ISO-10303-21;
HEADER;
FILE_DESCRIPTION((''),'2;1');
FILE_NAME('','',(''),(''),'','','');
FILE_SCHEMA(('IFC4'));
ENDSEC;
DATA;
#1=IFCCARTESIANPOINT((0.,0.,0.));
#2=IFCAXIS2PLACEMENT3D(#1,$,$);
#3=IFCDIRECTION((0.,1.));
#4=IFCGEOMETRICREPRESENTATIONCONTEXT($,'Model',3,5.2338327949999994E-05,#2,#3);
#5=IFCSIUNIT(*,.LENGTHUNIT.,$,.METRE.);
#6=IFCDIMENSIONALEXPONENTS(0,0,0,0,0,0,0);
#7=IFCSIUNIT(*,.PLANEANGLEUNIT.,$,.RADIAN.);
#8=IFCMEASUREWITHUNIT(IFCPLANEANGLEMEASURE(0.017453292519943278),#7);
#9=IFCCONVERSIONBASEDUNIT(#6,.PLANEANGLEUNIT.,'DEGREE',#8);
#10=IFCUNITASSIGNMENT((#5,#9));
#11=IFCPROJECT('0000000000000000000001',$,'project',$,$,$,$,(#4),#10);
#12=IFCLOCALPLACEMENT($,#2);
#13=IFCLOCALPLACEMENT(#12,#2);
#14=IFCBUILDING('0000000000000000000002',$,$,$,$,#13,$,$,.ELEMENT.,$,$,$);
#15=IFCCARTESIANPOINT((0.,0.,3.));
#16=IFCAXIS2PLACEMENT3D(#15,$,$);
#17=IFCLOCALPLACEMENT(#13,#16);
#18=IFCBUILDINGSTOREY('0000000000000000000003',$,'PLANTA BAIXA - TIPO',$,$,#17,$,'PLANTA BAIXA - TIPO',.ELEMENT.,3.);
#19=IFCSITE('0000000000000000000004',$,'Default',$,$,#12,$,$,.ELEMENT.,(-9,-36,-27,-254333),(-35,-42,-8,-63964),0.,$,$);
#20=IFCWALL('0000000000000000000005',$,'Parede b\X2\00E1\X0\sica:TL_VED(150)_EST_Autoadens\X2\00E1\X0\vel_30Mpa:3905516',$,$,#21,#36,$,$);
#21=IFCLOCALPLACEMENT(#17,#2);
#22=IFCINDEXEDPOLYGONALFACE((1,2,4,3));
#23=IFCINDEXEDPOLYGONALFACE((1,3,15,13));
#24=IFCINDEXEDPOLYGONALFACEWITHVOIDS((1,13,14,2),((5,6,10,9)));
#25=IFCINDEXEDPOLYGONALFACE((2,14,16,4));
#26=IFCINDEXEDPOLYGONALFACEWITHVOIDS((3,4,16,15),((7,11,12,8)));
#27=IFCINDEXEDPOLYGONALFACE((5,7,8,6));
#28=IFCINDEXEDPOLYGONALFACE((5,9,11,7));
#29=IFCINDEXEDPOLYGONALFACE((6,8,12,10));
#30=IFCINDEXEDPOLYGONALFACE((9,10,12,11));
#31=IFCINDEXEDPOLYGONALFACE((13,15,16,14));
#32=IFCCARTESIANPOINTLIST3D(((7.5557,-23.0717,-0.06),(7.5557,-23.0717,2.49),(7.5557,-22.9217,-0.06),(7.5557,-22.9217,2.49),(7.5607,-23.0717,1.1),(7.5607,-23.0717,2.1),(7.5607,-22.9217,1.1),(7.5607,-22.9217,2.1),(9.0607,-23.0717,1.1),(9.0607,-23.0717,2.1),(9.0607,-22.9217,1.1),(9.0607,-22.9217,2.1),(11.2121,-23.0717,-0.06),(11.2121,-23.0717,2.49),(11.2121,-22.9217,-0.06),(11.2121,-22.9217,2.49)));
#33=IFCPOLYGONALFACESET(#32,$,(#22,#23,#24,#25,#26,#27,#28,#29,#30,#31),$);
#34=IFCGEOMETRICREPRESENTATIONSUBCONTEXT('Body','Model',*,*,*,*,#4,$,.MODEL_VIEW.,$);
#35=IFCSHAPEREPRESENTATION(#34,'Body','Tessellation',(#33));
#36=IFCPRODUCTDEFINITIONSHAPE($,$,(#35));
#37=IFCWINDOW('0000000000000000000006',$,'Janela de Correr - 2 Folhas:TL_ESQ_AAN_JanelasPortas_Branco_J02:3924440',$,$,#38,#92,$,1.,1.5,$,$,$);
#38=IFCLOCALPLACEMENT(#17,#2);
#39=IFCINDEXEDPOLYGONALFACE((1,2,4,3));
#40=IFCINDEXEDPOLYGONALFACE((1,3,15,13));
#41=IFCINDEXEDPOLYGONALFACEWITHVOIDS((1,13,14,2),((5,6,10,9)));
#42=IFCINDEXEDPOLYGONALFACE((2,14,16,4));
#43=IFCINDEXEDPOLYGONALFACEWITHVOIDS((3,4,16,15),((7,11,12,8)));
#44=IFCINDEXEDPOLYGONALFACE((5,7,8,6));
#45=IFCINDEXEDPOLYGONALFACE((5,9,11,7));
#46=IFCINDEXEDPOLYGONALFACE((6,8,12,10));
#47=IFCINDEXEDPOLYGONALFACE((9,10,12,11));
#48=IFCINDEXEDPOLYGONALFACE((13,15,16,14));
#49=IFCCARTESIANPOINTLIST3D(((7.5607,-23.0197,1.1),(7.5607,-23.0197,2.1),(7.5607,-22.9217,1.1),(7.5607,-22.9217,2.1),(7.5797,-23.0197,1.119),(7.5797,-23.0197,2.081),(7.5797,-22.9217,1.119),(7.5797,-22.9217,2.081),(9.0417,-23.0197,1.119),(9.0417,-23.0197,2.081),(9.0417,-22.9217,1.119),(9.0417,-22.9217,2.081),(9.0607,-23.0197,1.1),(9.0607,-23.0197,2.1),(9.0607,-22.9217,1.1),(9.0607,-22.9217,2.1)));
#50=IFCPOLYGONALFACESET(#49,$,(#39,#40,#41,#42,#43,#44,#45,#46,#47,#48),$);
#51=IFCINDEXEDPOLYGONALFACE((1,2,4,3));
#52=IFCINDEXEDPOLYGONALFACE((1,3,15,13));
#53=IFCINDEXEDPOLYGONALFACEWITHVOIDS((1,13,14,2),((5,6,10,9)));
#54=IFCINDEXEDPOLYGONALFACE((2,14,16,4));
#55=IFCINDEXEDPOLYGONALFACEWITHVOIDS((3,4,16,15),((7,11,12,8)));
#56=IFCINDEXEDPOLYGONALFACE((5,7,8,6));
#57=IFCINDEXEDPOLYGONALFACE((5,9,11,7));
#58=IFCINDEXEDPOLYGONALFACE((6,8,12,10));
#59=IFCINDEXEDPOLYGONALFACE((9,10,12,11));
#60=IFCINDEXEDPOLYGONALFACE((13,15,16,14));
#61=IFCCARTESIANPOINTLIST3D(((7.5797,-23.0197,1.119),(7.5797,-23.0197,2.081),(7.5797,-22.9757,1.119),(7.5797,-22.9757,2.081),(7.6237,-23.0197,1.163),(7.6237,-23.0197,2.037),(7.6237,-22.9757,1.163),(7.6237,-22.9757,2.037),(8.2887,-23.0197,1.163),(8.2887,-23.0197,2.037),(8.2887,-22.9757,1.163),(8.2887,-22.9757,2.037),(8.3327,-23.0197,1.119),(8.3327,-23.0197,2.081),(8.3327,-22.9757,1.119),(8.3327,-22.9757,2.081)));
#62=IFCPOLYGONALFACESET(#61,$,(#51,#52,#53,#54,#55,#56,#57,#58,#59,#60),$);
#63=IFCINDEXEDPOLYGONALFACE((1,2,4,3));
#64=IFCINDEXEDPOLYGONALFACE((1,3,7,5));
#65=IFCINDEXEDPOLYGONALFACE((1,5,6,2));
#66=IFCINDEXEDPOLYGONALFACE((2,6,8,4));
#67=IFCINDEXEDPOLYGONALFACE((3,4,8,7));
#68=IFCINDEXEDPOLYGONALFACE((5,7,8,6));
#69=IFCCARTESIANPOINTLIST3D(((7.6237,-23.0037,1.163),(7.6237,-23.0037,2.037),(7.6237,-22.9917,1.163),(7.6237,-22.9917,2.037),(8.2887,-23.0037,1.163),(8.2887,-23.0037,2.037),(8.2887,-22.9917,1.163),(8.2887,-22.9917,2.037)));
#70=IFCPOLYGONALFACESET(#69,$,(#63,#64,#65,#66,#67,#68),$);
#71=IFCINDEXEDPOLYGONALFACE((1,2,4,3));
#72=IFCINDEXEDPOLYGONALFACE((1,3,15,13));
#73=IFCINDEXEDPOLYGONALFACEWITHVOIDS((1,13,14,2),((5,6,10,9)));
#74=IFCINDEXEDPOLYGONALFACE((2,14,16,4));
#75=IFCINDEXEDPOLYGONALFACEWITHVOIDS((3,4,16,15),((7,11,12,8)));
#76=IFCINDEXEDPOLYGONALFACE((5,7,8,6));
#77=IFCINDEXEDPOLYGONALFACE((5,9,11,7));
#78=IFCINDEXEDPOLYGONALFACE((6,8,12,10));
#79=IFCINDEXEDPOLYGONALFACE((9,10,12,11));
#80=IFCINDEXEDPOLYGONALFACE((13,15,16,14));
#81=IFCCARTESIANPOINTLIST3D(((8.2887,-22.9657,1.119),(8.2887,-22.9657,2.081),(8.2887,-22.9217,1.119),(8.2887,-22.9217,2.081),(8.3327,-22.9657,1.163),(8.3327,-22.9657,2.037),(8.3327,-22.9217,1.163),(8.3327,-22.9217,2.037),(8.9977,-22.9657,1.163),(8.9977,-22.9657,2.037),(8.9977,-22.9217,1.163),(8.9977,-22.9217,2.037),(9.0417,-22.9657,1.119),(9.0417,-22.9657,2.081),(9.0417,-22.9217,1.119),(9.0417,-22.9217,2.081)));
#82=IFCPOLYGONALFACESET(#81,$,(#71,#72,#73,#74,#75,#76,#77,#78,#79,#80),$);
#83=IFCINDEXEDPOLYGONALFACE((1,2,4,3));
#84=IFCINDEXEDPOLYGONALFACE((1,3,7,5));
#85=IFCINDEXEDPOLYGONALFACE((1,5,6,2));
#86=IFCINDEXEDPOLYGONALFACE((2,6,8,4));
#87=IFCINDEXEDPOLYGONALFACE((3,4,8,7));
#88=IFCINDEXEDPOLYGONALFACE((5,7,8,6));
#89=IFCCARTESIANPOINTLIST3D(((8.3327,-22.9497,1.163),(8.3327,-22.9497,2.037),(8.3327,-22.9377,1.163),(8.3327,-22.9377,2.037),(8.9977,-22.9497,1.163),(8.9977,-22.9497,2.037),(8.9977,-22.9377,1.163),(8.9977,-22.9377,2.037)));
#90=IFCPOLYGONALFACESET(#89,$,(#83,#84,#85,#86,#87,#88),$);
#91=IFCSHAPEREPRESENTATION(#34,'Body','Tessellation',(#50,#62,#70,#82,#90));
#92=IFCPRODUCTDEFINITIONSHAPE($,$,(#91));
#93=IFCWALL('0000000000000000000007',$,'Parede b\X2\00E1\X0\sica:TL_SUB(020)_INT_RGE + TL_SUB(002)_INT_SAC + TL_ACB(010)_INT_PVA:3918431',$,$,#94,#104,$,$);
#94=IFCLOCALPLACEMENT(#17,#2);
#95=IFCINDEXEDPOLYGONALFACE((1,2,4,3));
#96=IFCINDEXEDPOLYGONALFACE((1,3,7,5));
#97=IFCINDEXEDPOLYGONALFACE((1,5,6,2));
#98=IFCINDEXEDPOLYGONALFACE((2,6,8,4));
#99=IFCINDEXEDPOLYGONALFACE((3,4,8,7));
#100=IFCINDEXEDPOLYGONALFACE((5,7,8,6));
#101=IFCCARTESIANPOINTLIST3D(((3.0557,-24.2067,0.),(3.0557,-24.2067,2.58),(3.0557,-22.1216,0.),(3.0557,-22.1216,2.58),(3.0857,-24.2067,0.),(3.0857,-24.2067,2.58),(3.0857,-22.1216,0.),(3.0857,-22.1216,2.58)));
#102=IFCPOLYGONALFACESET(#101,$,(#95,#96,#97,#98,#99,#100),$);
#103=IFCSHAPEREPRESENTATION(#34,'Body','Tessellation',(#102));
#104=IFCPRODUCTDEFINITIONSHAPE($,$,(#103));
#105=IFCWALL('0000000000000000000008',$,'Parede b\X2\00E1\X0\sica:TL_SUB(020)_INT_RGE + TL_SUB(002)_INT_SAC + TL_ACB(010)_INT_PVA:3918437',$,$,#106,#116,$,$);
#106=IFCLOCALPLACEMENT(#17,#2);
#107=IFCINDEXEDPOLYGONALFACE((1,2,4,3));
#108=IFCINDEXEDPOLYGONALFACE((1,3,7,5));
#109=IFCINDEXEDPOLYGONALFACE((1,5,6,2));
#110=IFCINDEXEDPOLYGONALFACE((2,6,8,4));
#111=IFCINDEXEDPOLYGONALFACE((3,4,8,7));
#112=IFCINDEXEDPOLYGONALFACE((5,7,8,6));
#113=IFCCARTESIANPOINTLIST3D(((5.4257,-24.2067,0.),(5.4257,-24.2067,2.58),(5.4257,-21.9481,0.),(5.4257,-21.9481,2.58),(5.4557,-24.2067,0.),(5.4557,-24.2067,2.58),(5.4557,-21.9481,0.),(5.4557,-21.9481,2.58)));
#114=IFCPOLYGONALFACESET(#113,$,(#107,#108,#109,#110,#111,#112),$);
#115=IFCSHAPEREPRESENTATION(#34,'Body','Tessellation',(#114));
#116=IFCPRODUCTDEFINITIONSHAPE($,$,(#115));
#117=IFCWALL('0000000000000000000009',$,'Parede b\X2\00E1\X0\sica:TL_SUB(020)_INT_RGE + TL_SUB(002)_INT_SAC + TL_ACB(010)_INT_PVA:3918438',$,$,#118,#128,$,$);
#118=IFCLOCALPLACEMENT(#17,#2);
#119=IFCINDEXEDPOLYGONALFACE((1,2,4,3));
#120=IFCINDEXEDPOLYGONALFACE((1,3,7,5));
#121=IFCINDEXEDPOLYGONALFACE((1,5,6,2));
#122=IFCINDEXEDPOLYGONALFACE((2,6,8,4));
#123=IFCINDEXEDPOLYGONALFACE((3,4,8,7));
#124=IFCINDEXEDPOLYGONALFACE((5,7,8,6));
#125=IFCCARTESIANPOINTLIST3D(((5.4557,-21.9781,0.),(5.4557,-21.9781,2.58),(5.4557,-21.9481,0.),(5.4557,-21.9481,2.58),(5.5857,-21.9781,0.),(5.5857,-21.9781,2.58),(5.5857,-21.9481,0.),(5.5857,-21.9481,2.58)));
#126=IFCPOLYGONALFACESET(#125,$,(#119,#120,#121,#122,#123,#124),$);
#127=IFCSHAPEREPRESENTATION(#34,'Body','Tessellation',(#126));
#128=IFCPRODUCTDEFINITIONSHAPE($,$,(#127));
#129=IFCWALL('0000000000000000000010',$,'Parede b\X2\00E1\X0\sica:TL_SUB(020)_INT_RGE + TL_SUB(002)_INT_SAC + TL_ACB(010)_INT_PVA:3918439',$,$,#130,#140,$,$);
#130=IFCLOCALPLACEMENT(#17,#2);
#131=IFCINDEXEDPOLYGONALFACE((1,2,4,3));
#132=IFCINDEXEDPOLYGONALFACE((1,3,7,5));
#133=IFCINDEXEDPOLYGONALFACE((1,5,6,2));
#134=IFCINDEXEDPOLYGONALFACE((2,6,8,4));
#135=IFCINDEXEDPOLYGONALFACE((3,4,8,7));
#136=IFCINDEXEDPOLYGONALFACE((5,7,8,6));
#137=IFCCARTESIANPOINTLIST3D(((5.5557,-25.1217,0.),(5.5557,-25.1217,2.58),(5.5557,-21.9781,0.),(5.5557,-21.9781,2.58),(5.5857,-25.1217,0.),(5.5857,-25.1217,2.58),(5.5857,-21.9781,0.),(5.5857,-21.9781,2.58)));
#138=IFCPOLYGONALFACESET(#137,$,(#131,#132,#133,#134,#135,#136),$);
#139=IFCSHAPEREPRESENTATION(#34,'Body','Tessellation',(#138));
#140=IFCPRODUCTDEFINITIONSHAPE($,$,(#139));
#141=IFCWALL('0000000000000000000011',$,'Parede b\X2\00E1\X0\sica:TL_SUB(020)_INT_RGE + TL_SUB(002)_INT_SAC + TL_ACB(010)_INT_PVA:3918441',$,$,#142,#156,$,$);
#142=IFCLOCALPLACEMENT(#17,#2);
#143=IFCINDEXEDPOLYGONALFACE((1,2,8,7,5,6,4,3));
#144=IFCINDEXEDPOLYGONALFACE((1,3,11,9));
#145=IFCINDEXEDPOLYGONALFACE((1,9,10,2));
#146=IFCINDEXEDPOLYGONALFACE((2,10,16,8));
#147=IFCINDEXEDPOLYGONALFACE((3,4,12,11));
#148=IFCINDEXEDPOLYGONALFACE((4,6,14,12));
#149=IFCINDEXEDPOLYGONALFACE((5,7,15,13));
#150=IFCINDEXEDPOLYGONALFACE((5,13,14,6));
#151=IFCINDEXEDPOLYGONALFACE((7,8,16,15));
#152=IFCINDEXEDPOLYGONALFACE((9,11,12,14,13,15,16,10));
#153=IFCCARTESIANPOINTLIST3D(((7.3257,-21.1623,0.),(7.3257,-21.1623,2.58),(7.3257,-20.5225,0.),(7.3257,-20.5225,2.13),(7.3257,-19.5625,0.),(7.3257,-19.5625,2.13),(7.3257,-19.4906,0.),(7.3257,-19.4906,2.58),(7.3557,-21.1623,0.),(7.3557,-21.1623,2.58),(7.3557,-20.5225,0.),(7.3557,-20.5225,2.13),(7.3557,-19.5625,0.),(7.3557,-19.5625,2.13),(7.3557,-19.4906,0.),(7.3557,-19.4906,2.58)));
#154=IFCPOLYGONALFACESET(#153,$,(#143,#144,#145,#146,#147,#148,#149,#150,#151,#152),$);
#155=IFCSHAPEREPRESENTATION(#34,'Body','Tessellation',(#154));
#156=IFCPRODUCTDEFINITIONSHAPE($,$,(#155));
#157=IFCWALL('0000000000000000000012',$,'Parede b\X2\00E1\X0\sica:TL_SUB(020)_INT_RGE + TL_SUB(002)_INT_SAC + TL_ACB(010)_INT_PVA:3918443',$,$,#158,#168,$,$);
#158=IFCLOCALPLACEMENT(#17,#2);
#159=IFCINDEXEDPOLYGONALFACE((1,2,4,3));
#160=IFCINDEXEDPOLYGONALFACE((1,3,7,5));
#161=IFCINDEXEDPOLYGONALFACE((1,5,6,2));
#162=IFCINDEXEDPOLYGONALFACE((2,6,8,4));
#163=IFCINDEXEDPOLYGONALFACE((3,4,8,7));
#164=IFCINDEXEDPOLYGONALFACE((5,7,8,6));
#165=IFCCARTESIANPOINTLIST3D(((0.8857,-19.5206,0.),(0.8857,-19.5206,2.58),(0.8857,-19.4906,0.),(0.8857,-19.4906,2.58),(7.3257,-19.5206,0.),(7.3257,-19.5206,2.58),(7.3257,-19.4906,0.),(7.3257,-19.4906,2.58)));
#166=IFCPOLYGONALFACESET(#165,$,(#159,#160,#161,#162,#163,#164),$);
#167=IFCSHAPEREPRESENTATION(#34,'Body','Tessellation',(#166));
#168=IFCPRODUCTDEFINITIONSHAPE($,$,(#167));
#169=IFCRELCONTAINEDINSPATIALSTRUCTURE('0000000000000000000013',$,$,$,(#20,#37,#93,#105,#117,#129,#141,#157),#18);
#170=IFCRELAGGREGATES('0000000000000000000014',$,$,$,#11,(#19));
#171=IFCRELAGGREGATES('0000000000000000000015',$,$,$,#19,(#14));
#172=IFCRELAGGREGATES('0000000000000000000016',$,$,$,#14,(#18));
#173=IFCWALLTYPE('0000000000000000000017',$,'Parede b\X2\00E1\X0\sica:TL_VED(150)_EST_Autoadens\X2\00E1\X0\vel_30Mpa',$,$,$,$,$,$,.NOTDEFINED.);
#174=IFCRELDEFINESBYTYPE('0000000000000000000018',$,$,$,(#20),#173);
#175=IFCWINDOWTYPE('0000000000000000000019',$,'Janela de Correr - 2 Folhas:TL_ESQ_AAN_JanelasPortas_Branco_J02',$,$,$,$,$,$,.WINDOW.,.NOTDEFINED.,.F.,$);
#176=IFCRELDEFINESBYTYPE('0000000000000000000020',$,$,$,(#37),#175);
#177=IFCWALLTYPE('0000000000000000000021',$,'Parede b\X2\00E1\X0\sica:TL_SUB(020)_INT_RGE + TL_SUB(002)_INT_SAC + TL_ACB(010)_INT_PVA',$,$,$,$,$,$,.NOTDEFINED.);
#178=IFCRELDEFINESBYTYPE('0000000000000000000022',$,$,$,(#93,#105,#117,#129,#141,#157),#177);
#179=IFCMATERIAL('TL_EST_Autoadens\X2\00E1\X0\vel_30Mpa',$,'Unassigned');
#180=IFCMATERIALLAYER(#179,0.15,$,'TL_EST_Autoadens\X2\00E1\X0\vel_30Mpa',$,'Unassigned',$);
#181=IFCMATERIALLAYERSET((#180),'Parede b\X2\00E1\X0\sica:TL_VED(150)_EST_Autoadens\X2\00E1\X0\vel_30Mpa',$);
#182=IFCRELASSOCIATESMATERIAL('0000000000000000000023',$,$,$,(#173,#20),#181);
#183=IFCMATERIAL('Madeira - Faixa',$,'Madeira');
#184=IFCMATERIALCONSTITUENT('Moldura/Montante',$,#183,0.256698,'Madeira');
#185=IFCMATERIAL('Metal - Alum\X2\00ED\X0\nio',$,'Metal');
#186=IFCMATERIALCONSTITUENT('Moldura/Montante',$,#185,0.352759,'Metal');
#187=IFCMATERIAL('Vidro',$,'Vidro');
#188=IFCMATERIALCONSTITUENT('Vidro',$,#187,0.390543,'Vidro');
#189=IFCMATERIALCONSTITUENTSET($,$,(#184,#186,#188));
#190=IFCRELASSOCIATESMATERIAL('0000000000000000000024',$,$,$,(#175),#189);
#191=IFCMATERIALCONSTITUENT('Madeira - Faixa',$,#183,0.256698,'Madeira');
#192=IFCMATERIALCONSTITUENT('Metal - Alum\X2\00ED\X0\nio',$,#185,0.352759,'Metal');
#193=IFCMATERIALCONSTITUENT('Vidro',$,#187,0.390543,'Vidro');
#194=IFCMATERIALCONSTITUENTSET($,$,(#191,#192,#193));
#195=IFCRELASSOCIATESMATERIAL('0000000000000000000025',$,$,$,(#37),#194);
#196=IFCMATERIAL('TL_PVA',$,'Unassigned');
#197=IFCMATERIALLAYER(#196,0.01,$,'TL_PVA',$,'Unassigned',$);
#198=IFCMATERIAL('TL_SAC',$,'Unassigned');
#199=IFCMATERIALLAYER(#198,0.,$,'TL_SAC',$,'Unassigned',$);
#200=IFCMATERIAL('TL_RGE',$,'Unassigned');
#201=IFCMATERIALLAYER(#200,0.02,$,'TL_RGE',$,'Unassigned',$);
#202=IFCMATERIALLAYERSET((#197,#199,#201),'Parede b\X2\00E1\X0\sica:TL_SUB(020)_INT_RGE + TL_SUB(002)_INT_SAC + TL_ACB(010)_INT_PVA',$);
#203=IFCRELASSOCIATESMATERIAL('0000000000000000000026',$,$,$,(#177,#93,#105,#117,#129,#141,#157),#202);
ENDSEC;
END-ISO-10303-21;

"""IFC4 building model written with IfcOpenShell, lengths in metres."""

from ifc_helpers import new_model, entity, si_unit, converted_unit, direction, frame, frame_2d, origin, origin_2d_with_axis, place, context, subcontext, project, spatial, polyline, rectangle, outline, extrude, source, transform, mapped, material, layer, layer_set, layer_usage, constituent, constituent_set, type_object, type_shapes, element, fill, save


model = new_model("IFC4")

# Units and contexts
model_context = context("Model", 3, precision=5.2338327949999994e-05, world=origin(), true_north=direction((0.0, 1.0)))
body_context = subcontext(model_context, "Body", "Model", "MODEL_VIEW")
ifc_project = project(units=[si_unit("LENGTHUNIT", "METRE"), converted_unit("PLANEANGLEUNIT", "DEGREE", entity("IfcPlaneAngleMeasure", 0.017453292519943278), si_unit("PLANEANGLEUNIT", "RADIAN"), dimensions=[0, 0, 0, 0, 0, 0, 0])], contexts=[model_context])

# Site, building, storey
site_placement = place(None, frame((0.0, 0.0, 0.0)))
site = spatial("IfcSite", under=ifc_project, at=site_placement, Name="Default", CompositionType="ELEMENT", RefLatitude=(-9, -36, -27, -254333), RefLongitude=(-35, -42, -8, -63964), RefElevation=0.0)
building_placement = place(site_placement, origin())
building = spatial("IfcBuilding", under=site, at=building_placement, CompositionType="ELEMENT")
storey_placement = place(building_placement, frame((0.0, 0.0, 3.0)))
storey = spatial("IfcBuildingStorey", under=building, at=storey_placement, Name="PLANTA BAIXA - TIPO", LongName="PLANTA BAIXA - TIPO", CompositionType="ELEMENT", Elevation=3.0)

# Shared definitions
ifc_material_1 = material(Name="TL_EST_Autoadensável_30Mpa", Category="Unassigned")

# Wall, opening, window
ifc_material_2 = material(Name="Madeira - Faixa", Category="Madeira")
ifc_material_3 = material(Name="Metal - Alumínio", Category="Metal")
ifc_material_4 = material(Name="Vidro", Category="Vidro")
ifc_layer_1 = layer(ifc_material_1, 0.15, Name="TL_EST_Autoadensável_30Mpa", Category="Unassigned")
ifc_layer_set_1 = layer_set([ifc_layer_1], Name="Parede básica:TL_VED(150)_EST_Autoadensável_30Mpa")
ifc_layer_usage_1 = layer_usage(ifc_layer_set_1, "AXIS2", "POSITIVE", -0.075)
wall_type_1 = type_object("IfcWallType", Name="Parede básica:TL_VED(150)_EST_Autoadensável_30Mpa", PredefinedType="NOTDEFINED", material=ifc_layer_set_1)
wall_1_placement = place(storey_placement, frame((7.5557, -22.9967, -0.06)))
wall_1 = element("IfcWall", 1, at=wall_1_placement, inside=storey, type_object=wall_type_1, material=ifc_layer_usage_1, Name="Parede básica:TL_VED(150)_EST_Autoadensável_30Mpa:3905516", context=body_context, shape_type="SweptSolid", body=[
    extrude(rectangle(XDim=3.6564, YDim=0.15, at=frame_2d((1.8282, 0.0), x_axis=(-1.0, 0.0))), origin(), (0.0, 0.0, 1.0), 2.55),
])
opening_1_placement = place(wall_1_placement, frame((1.505, 0.075, 1.16)))
opening_1 = element("IfcOpeningElement", 2, at=opening_1_placement, cuts=wall_1, PredefinedType="OPENING", context=body_context, shape_type="SweptSolid", body=[
    extrude(rectangle(XDim=1.0, YDim=1.5, at=frame_2d((0.5, 0.75), x_axis=(-1.0, 0.0))), frame((0.0, 0.0, 0.0), z_axis=(0.0, -1.0, 0.0), x_axis=(0.0, 0.0, 1.0)), (0.0, 0.0, 1.0), 0.15),
])
ifc_constituent_1 = constituent(ifc_material_2, Name="Madeira - Faixa", Category="Madeira", fraction=0.256698)
ifc_constituent_2 = constituent(ifc_material_3, Name="Metal - Alumínio", Category="Metal", fraction=0.352759)
ifc_constituent_3 = constituent(ifc_material_4, Name="Vidro", Category="Vidro", fraction=0.390543)
ifc_constituent_set_1 = constituent_set(constituents=[ifc_constituent_1, ifc_constituent_2, ifc_constituent_3])
ifc_constituent_4 = constituent(ifc_material_2, Name="Moldura/Montante", Category="Madeira", fraction=0.256698)
ifc_constituent_5 = constituent(ifc_material_3, Name="Moldura/Montante", Category="Metal", fraction=0.352759)
ifc_constituent_6 = constituent(ifc_material_4, Name="Vidro", Category="Vidro", fraction=0.390543)
ifc_constituent_set_2 = constituent_set(constituents=[ifc_constituent_4, ifc_constituent_5, ifc_constituent_6])
window_type_1 = type_object("IfcWindowType", Name="Janela de Correr - 2 Folhas:TL_ESQ_AAN_JanelasPortas_Branco_J02", ParameterTakesPrecedence=False, PartitioningType="NOTDEFINED", PredefinedType="WINDOW", material=ifc_constituent_set_2)
shared_shape_1 = source(origin(), body_context, "Body", "SweptSolid", [
    extrude(outline(polyline([(-0.75, -0.5), (0.75, -0.5), (0.75, 0.5), (-0.75, 0.5), (-0.75, -0.5)]), holes=[polyline([(-0.731, -0.481), (-0.731, 0.481), (0.731, 0.481), (0.731, -0.481), (-0.731, -0.481)])]), frame((0.75, 0.0, 0.5), z_axis=(0.0, 1.0, 0.0), x_axis=(1.0, 0.0, 0.0)), (0.0, 0.0, 1.0), 0.098),
    extrude(outline(polyline([(-0.3765, -0.481), (0.3765, -0.481), (0.3765, 0.481), (-0.3765, 0.481), (-0.3765, -0.481)]), holes=[polyline([(-0.3325, -0.437), (-0.3325, 0.437), (0.3325, 0.437), (0.3325, -0.437), (-0.3325, -0.437)])]), frame((1.1045, 0.054, 0.5), z_axis=(0.0, 1.0, 0.0), x_axis=(1.0, 0.0, 0.0)), (0.0, 0.0, 1.0), 0.044),
    extrude(rectangle(XDim=0.012, YDim=0.665, at=origin_2d_with_axis()), frame((1.1045, 0.076, 0.063), z_axis=(0.0, 0.0, 1.0), x_axis=(0.0, -1.0, 0.0)), (0.0, 0.0, 1.0), 0.874),
    extrude(outline(polyline([(-0.481, -0.3765), (0.481, -0.3765), (0.481, 0.3765), (-0.481, 0.3765), (-0.481, -0.3765)]), holes=[polyline([(-0.437, -0.3325), (-0.437, 0.3325), (0.437, 0.3325), (0.437, -0.3325), (-0.437, -0.3325)])]), frame((0.3955, 0.0, 0.5), z_axis=(0.0, 1.0, 0.0), x_axis=(0.0, 0.0, -1.0)), (0.0, 0.0, 1.0), 0.044),
    extrude(rectangle(XDim=0.012, YDim=0.665, at=origin_2d_with_axis()), frame((0.3955, 0.022, 0.063), z_axis=(0.0, 0.0, 1.0), x_axis=(0.0, -1.0, 0.0)), (0.0, 0.0, 1.0), 0.874),
])
type_shapes(window_type_1, [shared_shape_1])
window_1_placement = place(opening_1_placement, frame((0.0, 0.0, 0.0), z_axis=(0.0, 0.0, 1.0), x_axis=(-1.0, 0.0, 0.0)))
window_1 = element("IfcWindow", 3, at=window_1_placement, inside=storey, type_object=window_type_1, material=ifc_constituent_set_1, Name="Janela de Correr - 2 Folhas:TL_ESQ_AAN_JanelasPortas_Branco_J02:3924440", OverallHeight=1.0, OverallWidth=1.5, context=body_context, shape_type="MappedRepresentation", body=[
    mapped(shared_shape_1, transform((0.0, 0.0, 0.0), scale=1.0)),
])
fill(opening_1, window_1)

# Walls
ifc_material_5 = material(Name="TL_PVA", Category="Unassigned")
ifc_layer_2 = layer(ifc_material_5, 0.01, Name="TL_PVA", Category="Unassigned")
ifc_material_6 = material(Name="TL_SAC", Category="Unassigned")
ifc_layer_3 = layer(ifc_material_6, 0.0, Name="TL_SAC", Category="Unassigned")
ifc_material_7 = material(Name="TL_RGE", Category="Unassigned")
ifc_layer_4 = layer(ifc_material_7, 0.02, Name="TL_RGE", Category="Unassigned")
ifc_layer_set_2 = layer_set([ifc_layer_2, ifc_layer_3, ifc_layer_4], Name="Parede básica:TL_SUB(020)_INT_RGE + TL_SUB(002)_INT_SAC + TL_ACB(010)_INT_PVA")
ifc_layer_usage_2 = layer_usage(ifc_layer_set_2, "AXIS2", "POSITIVE", -0.015)
wall_type_2 = type_object("IfcWallType", Name="Parede básica:TL_SUB(020)_INT_RGE + TL_SUB(002)_INT_SAC + TL_ACB(010)_INT_PVA", PredefinedType="NOTDEFINED", material=ifc_layer_set_2)
wall_2_placement = place(storey_placement, frame((3.0707, -24.2067, 0.0), z_axis=(0.0, 0.0, 1.0), x_axis=(0.0, 1.0, 0.0)))
element("IfcWall", 4, at=wall_2_placement, inside=storey, type_object=wall_type_2, material=ifc_layer_usage_2, Name="Parede básica:TL_SUB(020)_INT_RGE + TL_SUB(002)_INT_SAC + TL_ACB(010)_INT_PVA:3918431", context=body_context, shape_type="SweptSolid", body=[
    extrude(rectangle(XDim=2.0851, YDim=0.03, at=frame_2d((1.0426, 0.0), x_axis=(-1.0, 0.0))), origin(), (0.0, 0.0, 1.0), 2.58),
])
ifc_layer_usage_3 = layer_usage(ifc_layer_set_2, "AXIS2", "POSITIVE", -0.015)
wall_3_placement = place(storey_placement, frame((5.4407, -21.9481, 0.0), z_axis=(0.0, 0.0, 1.0), x_axis=(0.0, -1.0, 0.0)))
element("IfcWall", 5, at=wall_3_placement, inside=storey, type_object=wall_type_2, material=ifc_layer_usage_3, Name="Parede básica:TL_SUB(020)_INT_RGE + TL_SUB(002)_INT_SAC + TL_ACB(010)_INT_PVA:3918437", context=body_context, shape_type="SweptSolid", body=[
    extrude(rectangle(XDim=2.2587, YDim=0.03, at=frame_2d((1.1293, 0.0), x_axis=(-1.0, 0.0))), origin(), (0.0, 0.0, 1.0), 2.58),
])
ifc_layer_usage_4 = layer_usage(ifc_layer_set_2, "AXIS2", "POSITIVE", -0.015)
wall_4_placement = place(storey_placement, frame((5.5857, -21.9631, 0.0), z_axis=(0.0, 0.0, 1.0), x_axis=(-1.0, 0.0, 0.0)))
element("IfcWall", 6, at=wall_4_placement, inside=storey, type_object=wall_type_2, material=ifc_layer_usage_4, Name="Parede básica:TL_SUB(020)_INT_RGE + TL_SUB(002)_INT_SAC + TL_ACB(010)_INT_PVA:3918438", context=body_context, shape_type="SweptSolid", body=[
    extrude(rectangle(XDim=0.13, YDim=0.03, at=frame_2d((0.065, 0.0), x_axis=(-1.0, 0.0))), origin(), (0.0, 0.0, 1.0), 2.58),
])
ifc_layer_usage_5 = layer_usage(ifc_layer_set_2, "AXIS2", "POSITIVE", -0.015)
wall_5_placement = place(storey_placement, frame((5.5707, -25.1217, 0.0), z_axis=(0.0, 0.0, 1.0), x_axis=(0.0, 1.0, 0.0)))
element("IfcWall", 7, at=wall_5_placement, inside=storey, type_object=wall_type_2, material=ifc_layer_usage_5, Name="Parede básica:TL_SUB(020)_INT_RGE + TL_SUB(002)_INT_SAC + TL_ACB(010)_INT_PVA:3918439", context=body_context, shape_type="SweptSolid", body=[
    extrude(rectangle(XDim=3.1437, YDim=0.03, at=frame_2d((1.5718, 0.0), x_axis=(-1.0, 0.0))), origin(), (0.0, 0.0, 1.0), 2.58),
])

# Wall, opening
ifc_layer_usage_6 = layer_usage(ifc_layer_set_2, "AXIS2", "POSITIVE", -0.015)
wall_6_placement = place(storey_placement, frame((7.3407, -19.4906, 0.0), z_axis=(0.0, 0.0, 1.0), x_axis=(0.0, -1.0, 0.0)))
wall_6 = element("IfcWall", 8, at=wall_6_placement, inside=storey, type_object=wall_type_2, material=ifc_layer_usage_6, Name="Parede básica:TL_SUB(020)_INT_RGE + TL_SUB(002)_INT_SAC + TL_ACB(010)_INT_PVA:3918441", context=body_context, shape_type="SweptSolid", body=[
    extrude(rectangle(XDim=1.6717, YDim=0.03, at=frame_2d((0.8359, 0.0), x_axis=(-1.0, 0.0))), origin(), (0.0, 0.0, 1.0), 2.58),
])
opening_2_placement = place(wall_6_placement, frame((-19.4906, -7.3407, 0.0)))
element("IfcOpeningElement", 9, at=opening_2_placement, cuts=wall_6, PredefinedType="OPENING", context=body_context, shape_type="SweptSolid", body=[
    extrude(rectangle(XDim=2.13, YDim=0.96, at=frame_2d((0.0, 0.0), x_axis=(0.0, 1.0))), frame((20.0425, 5.8317, 1.065), z_axis=(0.0, 1.0, 0.0), x_axis=(-1.0, 0.0, 0.0)), (0.0, 0.0, 1.0), 3.048),
])

# Wall
ifc_layer_usage_7 = layer_usage(ifc_layer_set_2, "AXIS2", "NEGATIVE", 0.015)
wall_7_placement = place(storey_placement, frame((7.3257, -19.5056, 0.0), z_axis=(0.0, 0.0, 1.0), x_axis=(-1.0, 0.0, 0.0)))
element("IfcWall", 10, at=wall_7_placement, inside=storey, type_object=wall_type_2, material=ifc_layer_usage_7, Name="Parede básica:TL_SUB(020)_INT_RGE + TL_SUB(002)_INT_SAC + TL_ACB(010)_INT_PVA:3918443", context=body_context, shape_type="SweptSolid", body=[
    extrude(rectangle(XDim=6.44, YDim=0.03, at=frame_2d((3.22, 0.0), x_axis=(-1.0, 0.0))), origin(), (0.0, 0.0, 1.0), 2.58),
])

save(model, "model.ifc")
